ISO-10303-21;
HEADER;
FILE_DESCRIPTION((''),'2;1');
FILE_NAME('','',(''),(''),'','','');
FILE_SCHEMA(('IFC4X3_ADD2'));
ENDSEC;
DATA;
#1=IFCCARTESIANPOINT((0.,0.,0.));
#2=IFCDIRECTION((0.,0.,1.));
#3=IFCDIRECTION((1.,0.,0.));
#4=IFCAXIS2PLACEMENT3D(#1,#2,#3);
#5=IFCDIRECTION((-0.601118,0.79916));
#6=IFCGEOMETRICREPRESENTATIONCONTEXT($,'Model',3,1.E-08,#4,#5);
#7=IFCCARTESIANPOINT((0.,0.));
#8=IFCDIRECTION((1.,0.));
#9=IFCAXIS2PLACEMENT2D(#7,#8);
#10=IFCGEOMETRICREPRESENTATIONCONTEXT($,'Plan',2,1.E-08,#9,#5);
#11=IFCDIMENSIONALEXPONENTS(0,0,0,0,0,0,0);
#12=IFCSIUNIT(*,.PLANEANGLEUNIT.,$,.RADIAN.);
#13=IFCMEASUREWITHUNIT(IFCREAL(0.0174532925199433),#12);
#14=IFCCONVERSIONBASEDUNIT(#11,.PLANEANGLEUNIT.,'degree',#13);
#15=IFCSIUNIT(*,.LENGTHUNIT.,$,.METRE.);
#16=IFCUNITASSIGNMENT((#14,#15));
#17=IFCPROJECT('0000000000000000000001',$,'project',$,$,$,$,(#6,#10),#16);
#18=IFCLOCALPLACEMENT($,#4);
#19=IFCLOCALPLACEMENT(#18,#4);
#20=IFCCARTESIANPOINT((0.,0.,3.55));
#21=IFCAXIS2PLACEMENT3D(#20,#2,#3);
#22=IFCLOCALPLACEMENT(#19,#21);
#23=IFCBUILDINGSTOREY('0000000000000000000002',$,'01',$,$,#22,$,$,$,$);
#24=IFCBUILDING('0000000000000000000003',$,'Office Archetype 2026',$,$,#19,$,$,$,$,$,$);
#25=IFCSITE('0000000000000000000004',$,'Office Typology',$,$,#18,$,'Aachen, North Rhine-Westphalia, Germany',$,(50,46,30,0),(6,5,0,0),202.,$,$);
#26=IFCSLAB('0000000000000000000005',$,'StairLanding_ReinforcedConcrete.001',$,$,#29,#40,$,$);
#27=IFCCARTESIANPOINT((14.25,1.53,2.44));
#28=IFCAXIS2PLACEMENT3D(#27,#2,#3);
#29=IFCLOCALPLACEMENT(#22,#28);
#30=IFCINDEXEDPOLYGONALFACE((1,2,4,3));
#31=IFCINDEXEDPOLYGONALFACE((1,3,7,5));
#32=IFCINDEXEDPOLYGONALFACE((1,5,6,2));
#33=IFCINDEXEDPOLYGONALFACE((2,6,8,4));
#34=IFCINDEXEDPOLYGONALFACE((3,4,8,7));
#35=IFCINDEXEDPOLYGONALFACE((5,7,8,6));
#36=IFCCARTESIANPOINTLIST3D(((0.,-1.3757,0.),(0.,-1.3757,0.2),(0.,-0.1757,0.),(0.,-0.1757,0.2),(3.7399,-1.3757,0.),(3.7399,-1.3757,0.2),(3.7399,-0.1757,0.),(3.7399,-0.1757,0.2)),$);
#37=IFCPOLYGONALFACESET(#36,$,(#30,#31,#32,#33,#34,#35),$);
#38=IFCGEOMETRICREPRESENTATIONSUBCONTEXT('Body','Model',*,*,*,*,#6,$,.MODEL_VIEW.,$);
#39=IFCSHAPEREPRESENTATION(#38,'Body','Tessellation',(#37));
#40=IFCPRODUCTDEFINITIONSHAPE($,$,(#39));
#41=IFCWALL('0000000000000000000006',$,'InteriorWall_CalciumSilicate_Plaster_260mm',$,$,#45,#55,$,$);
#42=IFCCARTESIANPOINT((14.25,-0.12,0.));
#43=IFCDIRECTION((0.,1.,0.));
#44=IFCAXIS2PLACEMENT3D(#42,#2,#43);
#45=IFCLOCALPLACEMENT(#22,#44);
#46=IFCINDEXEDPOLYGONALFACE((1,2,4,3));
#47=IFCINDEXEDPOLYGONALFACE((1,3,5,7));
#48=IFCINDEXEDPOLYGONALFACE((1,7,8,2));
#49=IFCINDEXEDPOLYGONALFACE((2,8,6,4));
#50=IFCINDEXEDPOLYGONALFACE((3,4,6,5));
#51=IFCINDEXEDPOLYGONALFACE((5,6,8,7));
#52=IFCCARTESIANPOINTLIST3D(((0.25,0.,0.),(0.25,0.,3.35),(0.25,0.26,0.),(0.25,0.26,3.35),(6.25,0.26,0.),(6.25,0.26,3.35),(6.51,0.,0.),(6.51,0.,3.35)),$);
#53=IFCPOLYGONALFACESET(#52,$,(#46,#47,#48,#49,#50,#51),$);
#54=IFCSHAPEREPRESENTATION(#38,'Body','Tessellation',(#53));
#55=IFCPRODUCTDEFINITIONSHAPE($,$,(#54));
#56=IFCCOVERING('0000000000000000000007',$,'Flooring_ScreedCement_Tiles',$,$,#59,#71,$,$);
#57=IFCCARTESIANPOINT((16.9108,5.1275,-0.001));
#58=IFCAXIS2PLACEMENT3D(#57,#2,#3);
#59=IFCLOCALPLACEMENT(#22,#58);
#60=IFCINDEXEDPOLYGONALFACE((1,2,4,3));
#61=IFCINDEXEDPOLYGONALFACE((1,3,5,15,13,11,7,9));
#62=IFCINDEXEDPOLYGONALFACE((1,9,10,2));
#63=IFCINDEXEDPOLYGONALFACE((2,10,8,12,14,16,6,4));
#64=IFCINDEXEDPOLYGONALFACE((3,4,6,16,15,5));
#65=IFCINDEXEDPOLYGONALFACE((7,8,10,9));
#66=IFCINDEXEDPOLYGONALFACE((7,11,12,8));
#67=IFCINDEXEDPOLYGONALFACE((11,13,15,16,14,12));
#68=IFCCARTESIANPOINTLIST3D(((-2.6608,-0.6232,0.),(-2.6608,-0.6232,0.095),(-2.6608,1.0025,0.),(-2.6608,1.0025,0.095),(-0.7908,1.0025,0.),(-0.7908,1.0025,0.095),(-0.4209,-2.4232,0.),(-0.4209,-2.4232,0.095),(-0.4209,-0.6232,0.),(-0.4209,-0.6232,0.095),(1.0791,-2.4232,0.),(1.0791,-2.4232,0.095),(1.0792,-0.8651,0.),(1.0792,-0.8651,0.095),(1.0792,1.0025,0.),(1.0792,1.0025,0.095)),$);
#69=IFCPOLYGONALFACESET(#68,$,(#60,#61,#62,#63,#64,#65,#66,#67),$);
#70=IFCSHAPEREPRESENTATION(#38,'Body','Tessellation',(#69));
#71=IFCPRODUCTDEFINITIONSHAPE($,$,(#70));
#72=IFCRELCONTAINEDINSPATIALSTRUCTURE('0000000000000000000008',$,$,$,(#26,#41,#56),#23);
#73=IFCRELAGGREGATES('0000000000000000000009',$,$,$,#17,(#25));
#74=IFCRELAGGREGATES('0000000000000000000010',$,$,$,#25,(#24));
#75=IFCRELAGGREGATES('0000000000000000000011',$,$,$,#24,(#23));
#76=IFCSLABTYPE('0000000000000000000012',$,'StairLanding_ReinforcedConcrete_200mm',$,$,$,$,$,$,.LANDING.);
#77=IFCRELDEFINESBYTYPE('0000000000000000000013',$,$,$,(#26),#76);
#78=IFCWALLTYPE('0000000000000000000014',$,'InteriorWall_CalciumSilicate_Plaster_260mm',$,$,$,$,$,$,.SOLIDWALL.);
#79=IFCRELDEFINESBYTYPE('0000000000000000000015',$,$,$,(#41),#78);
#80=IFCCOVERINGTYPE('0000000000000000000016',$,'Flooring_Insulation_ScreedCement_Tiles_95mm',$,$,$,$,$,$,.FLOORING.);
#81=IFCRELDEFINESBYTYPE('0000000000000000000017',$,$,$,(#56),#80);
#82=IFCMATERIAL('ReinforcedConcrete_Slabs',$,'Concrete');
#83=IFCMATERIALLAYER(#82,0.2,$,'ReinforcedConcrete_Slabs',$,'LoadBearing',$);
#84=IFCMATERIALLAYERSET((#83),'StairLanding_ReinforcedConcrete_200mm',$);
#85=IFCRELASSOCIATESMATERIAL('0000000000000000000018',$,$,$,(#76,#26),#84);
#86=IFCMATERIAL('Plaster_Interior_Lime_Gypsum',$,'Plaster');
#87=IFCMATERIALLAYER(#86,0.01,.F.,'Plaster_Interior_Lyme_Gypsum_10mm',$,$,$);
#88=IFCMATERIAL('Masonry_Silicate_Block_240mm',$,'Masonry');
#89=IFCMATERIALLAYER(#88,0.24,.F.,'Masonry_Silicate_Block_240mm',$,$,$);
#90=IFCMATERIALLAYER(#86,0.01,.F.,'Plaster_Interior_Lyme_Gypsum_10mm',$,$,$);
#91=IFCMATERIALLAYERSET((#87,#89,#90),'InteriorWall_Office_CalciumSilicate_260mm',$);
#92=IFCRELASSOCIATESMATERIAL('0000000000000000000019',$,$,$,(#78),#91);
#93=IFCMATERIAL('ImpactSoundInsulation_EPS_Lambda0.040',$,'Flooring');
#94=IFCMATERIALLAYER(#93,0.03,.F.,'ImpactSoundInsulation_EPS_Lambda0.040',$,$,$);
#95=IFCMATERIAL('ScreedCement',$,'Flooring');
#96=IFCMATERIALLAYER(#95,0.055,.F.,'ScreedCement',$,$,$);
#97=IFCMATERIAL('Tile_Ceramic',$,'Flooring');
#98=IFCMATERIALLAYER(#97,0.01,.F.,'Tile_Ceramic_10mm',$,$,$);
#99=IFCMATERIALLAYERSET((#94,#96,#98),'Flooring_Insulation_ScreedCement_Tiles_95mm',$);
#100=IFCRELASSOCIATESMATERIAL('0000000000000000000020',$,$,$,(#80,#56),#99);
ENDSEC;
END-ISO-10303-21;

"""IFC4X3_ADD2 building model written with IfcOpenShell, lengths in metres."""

from ifc_helpers import new_model, entity, si_unit, converted_unit, direction, frame, origin_with_axes, origin_2d_with_axis, place, context, subcontext, project, spatial, line, indexed_curve, outline, extrude, material, layer, layer_set, layer_usage, type_object, element, save


model = new_model("IFC4X3_ADD2")

# Units and contexts
model_context = context("Model", 3, precision=1e-08, world=origin_with_axes(), true_north=direction((-0.601118, 0.79916)))
plan_context = context("Plan", 2, precision=1e-08, world=origin_2d_with_axis(), true_north=direction((-0.601118, 0.79916)))
body_context = subcontext(model_context, "Body", "Model", "MODEL_VIEW")
ifc_project = project(units=[converted_unit("PLANEANGLEUNIT", "degree", entity("IfcReal", 0.0174532925199433), si_unit("PLANEANGLEUNIT", "RADIAN"), dimensions=[0, 0, 0, 0, 0, 0, 0]), si_unit("LENGTHUNIT", "METRE")], contexts=[model_context, plan_context])

# Site, building, storey
site_placement = place(None, origin_with_axes())
site = spatial("IfcSite", under=ifc_project, at=site_placement, Name="Office Typology", LongName="Aachen, North Rhine-Westphalia, Germany", RefLatitude=(50, 46, 30, 0), RefLongitude=(6, 5, 0, 0), RefElevation=202.0)
building_placement = place(site_placement, origin_with_axes())
building = spatial("IfcBuilding", under=site, at=building_placement, Name="Office Archetype 2026")
storey_placement = place(building_placement, frame((0.0, 0.0, 3.55), z_axis=(0.0, 0.0, 1.0), x_axis=(1.0, 0.0, 0.0)))
storey = spatial("IfcBuildingStorey", under=building, at=storey_placement, Name="01")

# Slab
ifc_material_1 = material(Name="ReinforcedConcrete_Slabs", Category="Concrete")
ifc_layer_1 = layer(ifc_material_1, 0.2, Name="ReinforcedConcrete_Slabs", Category="LoadBearing")
ifc_layer_set_1 = layer_set([ifc_layer_1], Name="StairLanding_ReinforcedConcrete_200mm")
ifc_layer_usage_1 = layer_usage(ifc_layer_set_1, "AXIS3", "POSITIVE", 0.0)
slab_type_1 = type_object("IfcSlabType", Name="StairLanding_ReinforcedConcrete_200mm", PredefinedType="LANDING", material=ifc_layer_set_1)
slab_1_placement = place(storey_placement, frame((14.25, 1.53, 2.44), z_axis=(0.0, 0.0, 1.0), x_axis=(1.0, 0.0, 0.0)))
element("IfcSlab", 1, at=slab_1_placement, inside=storey, type_object=slab_type_1, material=ifc_layer_usage_1, Name="StairLanding_ReinforcedConcrete.001", context=body_context, shape_type="SweptSolid", body=[
    extrude(outline(indexed_curve([(3.7399, -0.1757), (3.7399, -1.3757), (0.0, -1.3757), (0.0, -0.1757), (3.7399, -0.1757)])), None, (0.0, 0.0, 1.0), 0.2),
])

# Wall
ifc_material_2 = material(Name="Plaster_Interior_Lime_Gypsum", Category="Plaster")
ifc_layer_2 = layer(ifc_material_2, 0.01, ventilated=False, Name="Plaster_Interior_Lyme_Gypsum_10mm")
ifc_material_3 = material(Name="Masonry_Silicate_Block_240mm", Category="Masonry")
ifc_layer_3 = layer(ifc_material_3, 0.24, ventilated=False, Name="Masonry_Silicate_Block_240mm")
ifc_layer_4 = layer(ifc_material_2, 0.01, ventilated=False, Name="Plaster_Interior_Lyme_Gypsum_10mm")
ifc_layer_set_2 = layer_set([ifc_layer_2, ifc_layer_3, ifc_layer_4], Name="InteriorWall_Office_CalciumSilicate_260mm")
wall_type = type_object("IfcWallType", Name="InteriorWall_CalciumSilicate_Plaster_260mm", PredefinedType="SOLIDWALL", material=ifc_layer_set_2)
wall_placement = place(storey_placement, frame((14.25, -0.12, 0.0), z_axis=(0.0, 0.0, 1.0), x_axis=(0.0, 1.0, 0.0)))
element("IfcWall", 2, at=wall_placement, inside=storey, type_object=wall_type, Name="InteriorWall_CalciumSilicate_Plaster_260mm", context=body_context, shape_type="SweptSolid", body=[
    extrude(outline(indexed_curve([(0.25, 0.0), (0.25, 0.26), (6.25, 0.26), (6.51, 0.0)], segments=[line(1, 2, 3, 4, 1)])), origin_with_axes(), (0.0, 0.0, 1.0), 3.35),
])

# Covering
ifc_material_4 = material(Name="ImpactSoundInsulation_EPS_Lambda0.040", Category="Flooring")
ifc_layer_5 = layer(ifc_material_4, 0.03, ventilated=False, Name="ImpactSoundInsulation_EPS_Lambda0.040")
ifc_material_5 = material(Name="ScreedCement", Category="Flooring")
ifc_layer_6 = layer(ifc_material_5, 0.055, ventilated=False, Name="ScreedCement")
ifc_material_6 = material(Name="Tile_Ceramic", Category="Flooring")
ifc_layer_7 = layer(ifc_material_6, 0.01, ventilated=False, Name="Tile_Ceramic_10mm")
ifc_layer_set_3 = layer_set([ifc_layer_5, ifc_layer_6, ifc_layer_7], Name="Flooring_Insulation_ScreedCement_Tiles_95mm")
ifc_layer_usage_2 = layer_usage(ifc_layer_set_3, "AXIS3", "POSITIVE", 0.0)
covering_type = type_object("IfcCoveringType", Name="Flooring_Insulation_ScreedCement_Tiles_95mm", PredefinedType="FLOORING", material=ifc_layer_set_3)
covering_placement = place(storey_placement, frame((16.9108, 5.1275, -0.001), z_axis=(0.0, 0.0, 1.0), x_axis=(1.0, 0.0, 0.0)))
element("IfcCovering", 3, at=covering_placement, inside=storey, type_object=covering_type, material=ifc_layer_usage_2, Name="Flooring_ScreedCement_Tiles", context=body_context, shape_type="SweptSolid", body=[
    extrude(outline(indexed_curve([(-0.7908, 1.0025), (-2.6608, 1.0025), (-2.6608, -0.6232), (-0.4209, -0.6232), (-0.4209, -2.4232), (1.0791, -2.4232), (1.0792, -0.8651), (1.0792, 1.0025), (-0.7908, 1.0025)])), None, (0.0, 0.0, 1.0), 0.095),
])

save(model, "model.ifc")
